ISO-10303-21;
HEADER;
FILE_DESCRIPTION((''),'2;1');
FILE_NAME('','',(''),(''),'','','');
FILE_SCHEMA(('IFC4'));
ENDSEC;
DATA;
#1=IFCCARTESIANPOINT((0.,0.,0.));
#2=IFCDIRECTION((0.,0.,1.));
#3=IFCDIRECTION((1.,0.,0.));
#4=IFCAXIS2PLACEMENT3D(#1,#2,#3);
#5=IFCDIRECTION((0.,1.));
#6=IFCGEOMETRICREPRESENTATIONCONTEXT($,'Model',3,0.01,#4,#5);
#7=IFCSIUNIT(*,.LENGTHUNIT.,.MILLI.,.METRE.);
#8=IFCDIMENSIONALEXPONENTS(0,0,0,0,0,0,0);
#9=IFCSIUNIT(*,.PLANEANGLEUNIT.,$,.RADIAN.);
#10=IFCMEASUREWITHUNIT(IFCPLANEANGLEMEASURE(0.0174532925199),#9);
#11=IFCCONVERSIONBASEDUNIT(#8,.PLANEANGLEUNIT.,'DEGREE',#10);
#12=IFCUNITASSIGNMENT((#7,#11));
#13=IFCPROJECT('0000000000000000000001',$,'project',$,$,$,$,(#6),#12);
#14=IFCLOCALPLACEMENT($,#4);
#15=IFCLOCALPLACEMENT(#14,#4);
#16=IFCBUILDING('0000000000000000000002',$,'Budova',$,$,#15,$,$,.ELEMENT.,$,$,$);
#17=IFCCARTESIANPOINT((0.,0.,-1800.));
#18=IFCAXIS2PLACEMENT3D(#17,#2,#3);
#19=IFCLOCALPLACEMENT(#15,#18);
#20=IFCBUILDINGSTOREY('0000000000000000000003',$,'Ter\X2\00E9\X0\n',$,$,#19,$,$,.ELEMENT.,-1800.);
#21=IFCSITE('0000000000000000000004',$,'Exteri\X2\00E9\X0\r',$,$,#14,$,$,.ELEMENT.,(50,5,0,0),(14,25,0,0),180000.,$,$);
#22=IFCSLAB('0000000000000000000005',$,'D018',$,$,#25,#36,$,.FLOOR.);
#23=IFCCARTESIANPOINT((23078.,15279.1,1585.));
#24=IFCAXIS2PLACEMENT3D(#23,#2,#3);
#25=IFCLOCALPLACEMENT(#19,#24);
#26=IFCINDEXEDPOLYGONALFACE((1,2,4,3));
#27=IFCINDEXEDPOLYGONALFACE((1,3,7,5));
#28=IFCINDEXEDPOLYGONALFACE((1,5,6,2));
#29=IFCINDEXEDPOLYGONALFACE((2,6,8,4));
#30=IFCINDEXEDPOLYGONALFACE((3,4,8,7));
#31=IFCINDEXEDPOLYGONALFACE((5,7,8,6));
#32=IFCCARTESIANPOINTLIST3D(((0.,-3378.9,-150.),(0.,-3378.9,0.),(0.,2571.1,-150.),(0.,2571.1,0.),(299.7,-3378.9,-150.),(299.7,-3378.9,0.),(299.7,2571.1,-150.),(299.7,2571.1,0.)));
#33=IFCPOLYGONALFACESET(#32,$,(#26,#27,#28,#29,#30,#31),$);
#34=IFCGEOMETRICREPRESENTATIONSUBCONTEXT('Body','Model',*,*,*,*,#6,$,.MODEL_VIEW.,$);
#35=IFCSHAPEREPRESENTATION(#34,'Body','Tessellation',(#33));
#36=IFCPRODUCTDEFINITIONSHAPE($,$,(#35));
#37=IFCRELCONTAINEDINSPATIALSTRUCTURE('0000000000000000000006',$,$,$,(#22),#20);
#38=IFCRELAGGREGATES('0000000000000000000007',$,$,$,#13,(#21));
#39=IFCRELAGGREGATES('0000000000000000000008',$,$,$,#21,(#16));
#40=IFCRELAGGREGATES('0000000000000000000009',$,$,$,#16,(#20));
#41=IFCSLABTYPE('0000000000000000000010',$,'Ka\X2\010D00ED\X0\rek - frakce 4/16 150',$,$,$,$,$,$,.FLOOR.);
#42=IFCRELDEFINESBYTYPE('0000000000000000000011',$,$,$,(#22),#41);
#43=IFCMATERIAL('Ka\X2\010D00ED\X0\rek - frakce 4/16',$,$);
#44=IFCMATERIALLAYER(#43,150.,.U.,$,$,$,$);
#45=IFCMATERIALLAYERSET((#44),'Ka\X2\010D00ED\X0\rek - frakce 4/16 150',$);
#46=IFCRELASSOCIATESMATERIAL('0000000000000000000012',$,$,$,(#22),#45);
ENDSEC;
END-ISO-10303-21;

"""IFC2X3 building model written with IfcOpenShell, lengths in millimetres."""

from ifc_helpers import new_model, entity, si_unit, converted_unit, direction, frame, origin_with_axes, place, context, subcontext, project, spatial, polyline, outline, extrude, material, layer, layer_set, layer_usage, type_object, element, save


model = new_model("IFC2X3")

# Units and contexts
model_context = context("Model", 3, precision=0.01, world=origin_with_axes(), true_north=direction((0.0, 1.0)))
body_context = subcontext(model_context, "Body", "Model", "MODEL_VIEW")
ifc_project = project(units=[si_unit("LENGTHUNIT", "METRE", prefix="MILLI"), converted_unit("PLANEANGLEUNIT", "DEGREE", entity("IfcPlaneAngleMeasure", 0.0174532925199), si_unit("PLANEANGLEUNIT", "RADIAN"), dimensions=[0, 0, 0, 0, 0, 0, 0])], contexts=[model_context])

# Site, building, storey
site_placement = place(None, origin_with_axes())
site = spatial("IfcSite", under=ifc_project, at=site_placement, Name="Exteriér", CompositionType="ELEMENT", RefLatitude=(50, 5, 0, 0), RefLongitude=(14, 25, 0, 0), RefElevation=180000.0)
building_placement = place(site_placement, origin_with_axes())
building = spatial("IfcBuilding", under=site, at=building_placement, Name="Budova", CompositionType="ELEMENT")
storey_placement = place(building_placement, frame((0.0, 0.0, -1800.0), z_axis=(0.0, 0.0, 1.0), x_axis=(1.0, 0.0, 0.0)))
storey = spatial("IfcBuildingStorey", under=building, at=storey_placement, Name="Terén", CompositionType="ELEMENT", Elevation=-1800.0)

# Slab
ifc_material_1 = material(Name="Kačírek - frakce 4/16")
ifc_layer_1 = layer(ifc_material_1, 150.0, ventilated="UNKNOWN")
ifc_layer_set_1 = layer_set([ifc_layer_1], Name="Kačírek - frakce 4/16 150")
slab_type_1 = type_object("IfcSlabType", Name="Kačírek - frakce 4/16 150", PredefinedType="FLOOR")
ifc_layer_usage_1 = layer_usage(ifc_layer_set_1, "AXIS3", "NEGATIVE", 150.0)
slab_1_placement = place(storey_placement, frame((23078.0, 15279.1, 1585.0), z_axis=(0.0, 0.0, 1.0), x_axis=(1.0, 0.0, 0.0)))
element("IfcSlab", 1, at=slab_1_placement, inside=storey, type_object=slab_type_1, material=ifc_layer_usage_1, Name="D018", PredefinedType="FLOOR", context=body_context, shape_type="SweptSolid", body=[
    extrude(outline(polyline([(0.0, -3378.9), (299.7, -3378.9), (299.7, 2571.1), (0.0, 2571.1), (0.0, -3378.9)])), frame((0.0, 0.0, -150.0), z_axis=(0.0, 0.0, 1.0), x_axis=(1.0, 0.0, 0.0)), (0.0, 0.0, 1.0), 150.0),
])

save(model, "model.ifc")
